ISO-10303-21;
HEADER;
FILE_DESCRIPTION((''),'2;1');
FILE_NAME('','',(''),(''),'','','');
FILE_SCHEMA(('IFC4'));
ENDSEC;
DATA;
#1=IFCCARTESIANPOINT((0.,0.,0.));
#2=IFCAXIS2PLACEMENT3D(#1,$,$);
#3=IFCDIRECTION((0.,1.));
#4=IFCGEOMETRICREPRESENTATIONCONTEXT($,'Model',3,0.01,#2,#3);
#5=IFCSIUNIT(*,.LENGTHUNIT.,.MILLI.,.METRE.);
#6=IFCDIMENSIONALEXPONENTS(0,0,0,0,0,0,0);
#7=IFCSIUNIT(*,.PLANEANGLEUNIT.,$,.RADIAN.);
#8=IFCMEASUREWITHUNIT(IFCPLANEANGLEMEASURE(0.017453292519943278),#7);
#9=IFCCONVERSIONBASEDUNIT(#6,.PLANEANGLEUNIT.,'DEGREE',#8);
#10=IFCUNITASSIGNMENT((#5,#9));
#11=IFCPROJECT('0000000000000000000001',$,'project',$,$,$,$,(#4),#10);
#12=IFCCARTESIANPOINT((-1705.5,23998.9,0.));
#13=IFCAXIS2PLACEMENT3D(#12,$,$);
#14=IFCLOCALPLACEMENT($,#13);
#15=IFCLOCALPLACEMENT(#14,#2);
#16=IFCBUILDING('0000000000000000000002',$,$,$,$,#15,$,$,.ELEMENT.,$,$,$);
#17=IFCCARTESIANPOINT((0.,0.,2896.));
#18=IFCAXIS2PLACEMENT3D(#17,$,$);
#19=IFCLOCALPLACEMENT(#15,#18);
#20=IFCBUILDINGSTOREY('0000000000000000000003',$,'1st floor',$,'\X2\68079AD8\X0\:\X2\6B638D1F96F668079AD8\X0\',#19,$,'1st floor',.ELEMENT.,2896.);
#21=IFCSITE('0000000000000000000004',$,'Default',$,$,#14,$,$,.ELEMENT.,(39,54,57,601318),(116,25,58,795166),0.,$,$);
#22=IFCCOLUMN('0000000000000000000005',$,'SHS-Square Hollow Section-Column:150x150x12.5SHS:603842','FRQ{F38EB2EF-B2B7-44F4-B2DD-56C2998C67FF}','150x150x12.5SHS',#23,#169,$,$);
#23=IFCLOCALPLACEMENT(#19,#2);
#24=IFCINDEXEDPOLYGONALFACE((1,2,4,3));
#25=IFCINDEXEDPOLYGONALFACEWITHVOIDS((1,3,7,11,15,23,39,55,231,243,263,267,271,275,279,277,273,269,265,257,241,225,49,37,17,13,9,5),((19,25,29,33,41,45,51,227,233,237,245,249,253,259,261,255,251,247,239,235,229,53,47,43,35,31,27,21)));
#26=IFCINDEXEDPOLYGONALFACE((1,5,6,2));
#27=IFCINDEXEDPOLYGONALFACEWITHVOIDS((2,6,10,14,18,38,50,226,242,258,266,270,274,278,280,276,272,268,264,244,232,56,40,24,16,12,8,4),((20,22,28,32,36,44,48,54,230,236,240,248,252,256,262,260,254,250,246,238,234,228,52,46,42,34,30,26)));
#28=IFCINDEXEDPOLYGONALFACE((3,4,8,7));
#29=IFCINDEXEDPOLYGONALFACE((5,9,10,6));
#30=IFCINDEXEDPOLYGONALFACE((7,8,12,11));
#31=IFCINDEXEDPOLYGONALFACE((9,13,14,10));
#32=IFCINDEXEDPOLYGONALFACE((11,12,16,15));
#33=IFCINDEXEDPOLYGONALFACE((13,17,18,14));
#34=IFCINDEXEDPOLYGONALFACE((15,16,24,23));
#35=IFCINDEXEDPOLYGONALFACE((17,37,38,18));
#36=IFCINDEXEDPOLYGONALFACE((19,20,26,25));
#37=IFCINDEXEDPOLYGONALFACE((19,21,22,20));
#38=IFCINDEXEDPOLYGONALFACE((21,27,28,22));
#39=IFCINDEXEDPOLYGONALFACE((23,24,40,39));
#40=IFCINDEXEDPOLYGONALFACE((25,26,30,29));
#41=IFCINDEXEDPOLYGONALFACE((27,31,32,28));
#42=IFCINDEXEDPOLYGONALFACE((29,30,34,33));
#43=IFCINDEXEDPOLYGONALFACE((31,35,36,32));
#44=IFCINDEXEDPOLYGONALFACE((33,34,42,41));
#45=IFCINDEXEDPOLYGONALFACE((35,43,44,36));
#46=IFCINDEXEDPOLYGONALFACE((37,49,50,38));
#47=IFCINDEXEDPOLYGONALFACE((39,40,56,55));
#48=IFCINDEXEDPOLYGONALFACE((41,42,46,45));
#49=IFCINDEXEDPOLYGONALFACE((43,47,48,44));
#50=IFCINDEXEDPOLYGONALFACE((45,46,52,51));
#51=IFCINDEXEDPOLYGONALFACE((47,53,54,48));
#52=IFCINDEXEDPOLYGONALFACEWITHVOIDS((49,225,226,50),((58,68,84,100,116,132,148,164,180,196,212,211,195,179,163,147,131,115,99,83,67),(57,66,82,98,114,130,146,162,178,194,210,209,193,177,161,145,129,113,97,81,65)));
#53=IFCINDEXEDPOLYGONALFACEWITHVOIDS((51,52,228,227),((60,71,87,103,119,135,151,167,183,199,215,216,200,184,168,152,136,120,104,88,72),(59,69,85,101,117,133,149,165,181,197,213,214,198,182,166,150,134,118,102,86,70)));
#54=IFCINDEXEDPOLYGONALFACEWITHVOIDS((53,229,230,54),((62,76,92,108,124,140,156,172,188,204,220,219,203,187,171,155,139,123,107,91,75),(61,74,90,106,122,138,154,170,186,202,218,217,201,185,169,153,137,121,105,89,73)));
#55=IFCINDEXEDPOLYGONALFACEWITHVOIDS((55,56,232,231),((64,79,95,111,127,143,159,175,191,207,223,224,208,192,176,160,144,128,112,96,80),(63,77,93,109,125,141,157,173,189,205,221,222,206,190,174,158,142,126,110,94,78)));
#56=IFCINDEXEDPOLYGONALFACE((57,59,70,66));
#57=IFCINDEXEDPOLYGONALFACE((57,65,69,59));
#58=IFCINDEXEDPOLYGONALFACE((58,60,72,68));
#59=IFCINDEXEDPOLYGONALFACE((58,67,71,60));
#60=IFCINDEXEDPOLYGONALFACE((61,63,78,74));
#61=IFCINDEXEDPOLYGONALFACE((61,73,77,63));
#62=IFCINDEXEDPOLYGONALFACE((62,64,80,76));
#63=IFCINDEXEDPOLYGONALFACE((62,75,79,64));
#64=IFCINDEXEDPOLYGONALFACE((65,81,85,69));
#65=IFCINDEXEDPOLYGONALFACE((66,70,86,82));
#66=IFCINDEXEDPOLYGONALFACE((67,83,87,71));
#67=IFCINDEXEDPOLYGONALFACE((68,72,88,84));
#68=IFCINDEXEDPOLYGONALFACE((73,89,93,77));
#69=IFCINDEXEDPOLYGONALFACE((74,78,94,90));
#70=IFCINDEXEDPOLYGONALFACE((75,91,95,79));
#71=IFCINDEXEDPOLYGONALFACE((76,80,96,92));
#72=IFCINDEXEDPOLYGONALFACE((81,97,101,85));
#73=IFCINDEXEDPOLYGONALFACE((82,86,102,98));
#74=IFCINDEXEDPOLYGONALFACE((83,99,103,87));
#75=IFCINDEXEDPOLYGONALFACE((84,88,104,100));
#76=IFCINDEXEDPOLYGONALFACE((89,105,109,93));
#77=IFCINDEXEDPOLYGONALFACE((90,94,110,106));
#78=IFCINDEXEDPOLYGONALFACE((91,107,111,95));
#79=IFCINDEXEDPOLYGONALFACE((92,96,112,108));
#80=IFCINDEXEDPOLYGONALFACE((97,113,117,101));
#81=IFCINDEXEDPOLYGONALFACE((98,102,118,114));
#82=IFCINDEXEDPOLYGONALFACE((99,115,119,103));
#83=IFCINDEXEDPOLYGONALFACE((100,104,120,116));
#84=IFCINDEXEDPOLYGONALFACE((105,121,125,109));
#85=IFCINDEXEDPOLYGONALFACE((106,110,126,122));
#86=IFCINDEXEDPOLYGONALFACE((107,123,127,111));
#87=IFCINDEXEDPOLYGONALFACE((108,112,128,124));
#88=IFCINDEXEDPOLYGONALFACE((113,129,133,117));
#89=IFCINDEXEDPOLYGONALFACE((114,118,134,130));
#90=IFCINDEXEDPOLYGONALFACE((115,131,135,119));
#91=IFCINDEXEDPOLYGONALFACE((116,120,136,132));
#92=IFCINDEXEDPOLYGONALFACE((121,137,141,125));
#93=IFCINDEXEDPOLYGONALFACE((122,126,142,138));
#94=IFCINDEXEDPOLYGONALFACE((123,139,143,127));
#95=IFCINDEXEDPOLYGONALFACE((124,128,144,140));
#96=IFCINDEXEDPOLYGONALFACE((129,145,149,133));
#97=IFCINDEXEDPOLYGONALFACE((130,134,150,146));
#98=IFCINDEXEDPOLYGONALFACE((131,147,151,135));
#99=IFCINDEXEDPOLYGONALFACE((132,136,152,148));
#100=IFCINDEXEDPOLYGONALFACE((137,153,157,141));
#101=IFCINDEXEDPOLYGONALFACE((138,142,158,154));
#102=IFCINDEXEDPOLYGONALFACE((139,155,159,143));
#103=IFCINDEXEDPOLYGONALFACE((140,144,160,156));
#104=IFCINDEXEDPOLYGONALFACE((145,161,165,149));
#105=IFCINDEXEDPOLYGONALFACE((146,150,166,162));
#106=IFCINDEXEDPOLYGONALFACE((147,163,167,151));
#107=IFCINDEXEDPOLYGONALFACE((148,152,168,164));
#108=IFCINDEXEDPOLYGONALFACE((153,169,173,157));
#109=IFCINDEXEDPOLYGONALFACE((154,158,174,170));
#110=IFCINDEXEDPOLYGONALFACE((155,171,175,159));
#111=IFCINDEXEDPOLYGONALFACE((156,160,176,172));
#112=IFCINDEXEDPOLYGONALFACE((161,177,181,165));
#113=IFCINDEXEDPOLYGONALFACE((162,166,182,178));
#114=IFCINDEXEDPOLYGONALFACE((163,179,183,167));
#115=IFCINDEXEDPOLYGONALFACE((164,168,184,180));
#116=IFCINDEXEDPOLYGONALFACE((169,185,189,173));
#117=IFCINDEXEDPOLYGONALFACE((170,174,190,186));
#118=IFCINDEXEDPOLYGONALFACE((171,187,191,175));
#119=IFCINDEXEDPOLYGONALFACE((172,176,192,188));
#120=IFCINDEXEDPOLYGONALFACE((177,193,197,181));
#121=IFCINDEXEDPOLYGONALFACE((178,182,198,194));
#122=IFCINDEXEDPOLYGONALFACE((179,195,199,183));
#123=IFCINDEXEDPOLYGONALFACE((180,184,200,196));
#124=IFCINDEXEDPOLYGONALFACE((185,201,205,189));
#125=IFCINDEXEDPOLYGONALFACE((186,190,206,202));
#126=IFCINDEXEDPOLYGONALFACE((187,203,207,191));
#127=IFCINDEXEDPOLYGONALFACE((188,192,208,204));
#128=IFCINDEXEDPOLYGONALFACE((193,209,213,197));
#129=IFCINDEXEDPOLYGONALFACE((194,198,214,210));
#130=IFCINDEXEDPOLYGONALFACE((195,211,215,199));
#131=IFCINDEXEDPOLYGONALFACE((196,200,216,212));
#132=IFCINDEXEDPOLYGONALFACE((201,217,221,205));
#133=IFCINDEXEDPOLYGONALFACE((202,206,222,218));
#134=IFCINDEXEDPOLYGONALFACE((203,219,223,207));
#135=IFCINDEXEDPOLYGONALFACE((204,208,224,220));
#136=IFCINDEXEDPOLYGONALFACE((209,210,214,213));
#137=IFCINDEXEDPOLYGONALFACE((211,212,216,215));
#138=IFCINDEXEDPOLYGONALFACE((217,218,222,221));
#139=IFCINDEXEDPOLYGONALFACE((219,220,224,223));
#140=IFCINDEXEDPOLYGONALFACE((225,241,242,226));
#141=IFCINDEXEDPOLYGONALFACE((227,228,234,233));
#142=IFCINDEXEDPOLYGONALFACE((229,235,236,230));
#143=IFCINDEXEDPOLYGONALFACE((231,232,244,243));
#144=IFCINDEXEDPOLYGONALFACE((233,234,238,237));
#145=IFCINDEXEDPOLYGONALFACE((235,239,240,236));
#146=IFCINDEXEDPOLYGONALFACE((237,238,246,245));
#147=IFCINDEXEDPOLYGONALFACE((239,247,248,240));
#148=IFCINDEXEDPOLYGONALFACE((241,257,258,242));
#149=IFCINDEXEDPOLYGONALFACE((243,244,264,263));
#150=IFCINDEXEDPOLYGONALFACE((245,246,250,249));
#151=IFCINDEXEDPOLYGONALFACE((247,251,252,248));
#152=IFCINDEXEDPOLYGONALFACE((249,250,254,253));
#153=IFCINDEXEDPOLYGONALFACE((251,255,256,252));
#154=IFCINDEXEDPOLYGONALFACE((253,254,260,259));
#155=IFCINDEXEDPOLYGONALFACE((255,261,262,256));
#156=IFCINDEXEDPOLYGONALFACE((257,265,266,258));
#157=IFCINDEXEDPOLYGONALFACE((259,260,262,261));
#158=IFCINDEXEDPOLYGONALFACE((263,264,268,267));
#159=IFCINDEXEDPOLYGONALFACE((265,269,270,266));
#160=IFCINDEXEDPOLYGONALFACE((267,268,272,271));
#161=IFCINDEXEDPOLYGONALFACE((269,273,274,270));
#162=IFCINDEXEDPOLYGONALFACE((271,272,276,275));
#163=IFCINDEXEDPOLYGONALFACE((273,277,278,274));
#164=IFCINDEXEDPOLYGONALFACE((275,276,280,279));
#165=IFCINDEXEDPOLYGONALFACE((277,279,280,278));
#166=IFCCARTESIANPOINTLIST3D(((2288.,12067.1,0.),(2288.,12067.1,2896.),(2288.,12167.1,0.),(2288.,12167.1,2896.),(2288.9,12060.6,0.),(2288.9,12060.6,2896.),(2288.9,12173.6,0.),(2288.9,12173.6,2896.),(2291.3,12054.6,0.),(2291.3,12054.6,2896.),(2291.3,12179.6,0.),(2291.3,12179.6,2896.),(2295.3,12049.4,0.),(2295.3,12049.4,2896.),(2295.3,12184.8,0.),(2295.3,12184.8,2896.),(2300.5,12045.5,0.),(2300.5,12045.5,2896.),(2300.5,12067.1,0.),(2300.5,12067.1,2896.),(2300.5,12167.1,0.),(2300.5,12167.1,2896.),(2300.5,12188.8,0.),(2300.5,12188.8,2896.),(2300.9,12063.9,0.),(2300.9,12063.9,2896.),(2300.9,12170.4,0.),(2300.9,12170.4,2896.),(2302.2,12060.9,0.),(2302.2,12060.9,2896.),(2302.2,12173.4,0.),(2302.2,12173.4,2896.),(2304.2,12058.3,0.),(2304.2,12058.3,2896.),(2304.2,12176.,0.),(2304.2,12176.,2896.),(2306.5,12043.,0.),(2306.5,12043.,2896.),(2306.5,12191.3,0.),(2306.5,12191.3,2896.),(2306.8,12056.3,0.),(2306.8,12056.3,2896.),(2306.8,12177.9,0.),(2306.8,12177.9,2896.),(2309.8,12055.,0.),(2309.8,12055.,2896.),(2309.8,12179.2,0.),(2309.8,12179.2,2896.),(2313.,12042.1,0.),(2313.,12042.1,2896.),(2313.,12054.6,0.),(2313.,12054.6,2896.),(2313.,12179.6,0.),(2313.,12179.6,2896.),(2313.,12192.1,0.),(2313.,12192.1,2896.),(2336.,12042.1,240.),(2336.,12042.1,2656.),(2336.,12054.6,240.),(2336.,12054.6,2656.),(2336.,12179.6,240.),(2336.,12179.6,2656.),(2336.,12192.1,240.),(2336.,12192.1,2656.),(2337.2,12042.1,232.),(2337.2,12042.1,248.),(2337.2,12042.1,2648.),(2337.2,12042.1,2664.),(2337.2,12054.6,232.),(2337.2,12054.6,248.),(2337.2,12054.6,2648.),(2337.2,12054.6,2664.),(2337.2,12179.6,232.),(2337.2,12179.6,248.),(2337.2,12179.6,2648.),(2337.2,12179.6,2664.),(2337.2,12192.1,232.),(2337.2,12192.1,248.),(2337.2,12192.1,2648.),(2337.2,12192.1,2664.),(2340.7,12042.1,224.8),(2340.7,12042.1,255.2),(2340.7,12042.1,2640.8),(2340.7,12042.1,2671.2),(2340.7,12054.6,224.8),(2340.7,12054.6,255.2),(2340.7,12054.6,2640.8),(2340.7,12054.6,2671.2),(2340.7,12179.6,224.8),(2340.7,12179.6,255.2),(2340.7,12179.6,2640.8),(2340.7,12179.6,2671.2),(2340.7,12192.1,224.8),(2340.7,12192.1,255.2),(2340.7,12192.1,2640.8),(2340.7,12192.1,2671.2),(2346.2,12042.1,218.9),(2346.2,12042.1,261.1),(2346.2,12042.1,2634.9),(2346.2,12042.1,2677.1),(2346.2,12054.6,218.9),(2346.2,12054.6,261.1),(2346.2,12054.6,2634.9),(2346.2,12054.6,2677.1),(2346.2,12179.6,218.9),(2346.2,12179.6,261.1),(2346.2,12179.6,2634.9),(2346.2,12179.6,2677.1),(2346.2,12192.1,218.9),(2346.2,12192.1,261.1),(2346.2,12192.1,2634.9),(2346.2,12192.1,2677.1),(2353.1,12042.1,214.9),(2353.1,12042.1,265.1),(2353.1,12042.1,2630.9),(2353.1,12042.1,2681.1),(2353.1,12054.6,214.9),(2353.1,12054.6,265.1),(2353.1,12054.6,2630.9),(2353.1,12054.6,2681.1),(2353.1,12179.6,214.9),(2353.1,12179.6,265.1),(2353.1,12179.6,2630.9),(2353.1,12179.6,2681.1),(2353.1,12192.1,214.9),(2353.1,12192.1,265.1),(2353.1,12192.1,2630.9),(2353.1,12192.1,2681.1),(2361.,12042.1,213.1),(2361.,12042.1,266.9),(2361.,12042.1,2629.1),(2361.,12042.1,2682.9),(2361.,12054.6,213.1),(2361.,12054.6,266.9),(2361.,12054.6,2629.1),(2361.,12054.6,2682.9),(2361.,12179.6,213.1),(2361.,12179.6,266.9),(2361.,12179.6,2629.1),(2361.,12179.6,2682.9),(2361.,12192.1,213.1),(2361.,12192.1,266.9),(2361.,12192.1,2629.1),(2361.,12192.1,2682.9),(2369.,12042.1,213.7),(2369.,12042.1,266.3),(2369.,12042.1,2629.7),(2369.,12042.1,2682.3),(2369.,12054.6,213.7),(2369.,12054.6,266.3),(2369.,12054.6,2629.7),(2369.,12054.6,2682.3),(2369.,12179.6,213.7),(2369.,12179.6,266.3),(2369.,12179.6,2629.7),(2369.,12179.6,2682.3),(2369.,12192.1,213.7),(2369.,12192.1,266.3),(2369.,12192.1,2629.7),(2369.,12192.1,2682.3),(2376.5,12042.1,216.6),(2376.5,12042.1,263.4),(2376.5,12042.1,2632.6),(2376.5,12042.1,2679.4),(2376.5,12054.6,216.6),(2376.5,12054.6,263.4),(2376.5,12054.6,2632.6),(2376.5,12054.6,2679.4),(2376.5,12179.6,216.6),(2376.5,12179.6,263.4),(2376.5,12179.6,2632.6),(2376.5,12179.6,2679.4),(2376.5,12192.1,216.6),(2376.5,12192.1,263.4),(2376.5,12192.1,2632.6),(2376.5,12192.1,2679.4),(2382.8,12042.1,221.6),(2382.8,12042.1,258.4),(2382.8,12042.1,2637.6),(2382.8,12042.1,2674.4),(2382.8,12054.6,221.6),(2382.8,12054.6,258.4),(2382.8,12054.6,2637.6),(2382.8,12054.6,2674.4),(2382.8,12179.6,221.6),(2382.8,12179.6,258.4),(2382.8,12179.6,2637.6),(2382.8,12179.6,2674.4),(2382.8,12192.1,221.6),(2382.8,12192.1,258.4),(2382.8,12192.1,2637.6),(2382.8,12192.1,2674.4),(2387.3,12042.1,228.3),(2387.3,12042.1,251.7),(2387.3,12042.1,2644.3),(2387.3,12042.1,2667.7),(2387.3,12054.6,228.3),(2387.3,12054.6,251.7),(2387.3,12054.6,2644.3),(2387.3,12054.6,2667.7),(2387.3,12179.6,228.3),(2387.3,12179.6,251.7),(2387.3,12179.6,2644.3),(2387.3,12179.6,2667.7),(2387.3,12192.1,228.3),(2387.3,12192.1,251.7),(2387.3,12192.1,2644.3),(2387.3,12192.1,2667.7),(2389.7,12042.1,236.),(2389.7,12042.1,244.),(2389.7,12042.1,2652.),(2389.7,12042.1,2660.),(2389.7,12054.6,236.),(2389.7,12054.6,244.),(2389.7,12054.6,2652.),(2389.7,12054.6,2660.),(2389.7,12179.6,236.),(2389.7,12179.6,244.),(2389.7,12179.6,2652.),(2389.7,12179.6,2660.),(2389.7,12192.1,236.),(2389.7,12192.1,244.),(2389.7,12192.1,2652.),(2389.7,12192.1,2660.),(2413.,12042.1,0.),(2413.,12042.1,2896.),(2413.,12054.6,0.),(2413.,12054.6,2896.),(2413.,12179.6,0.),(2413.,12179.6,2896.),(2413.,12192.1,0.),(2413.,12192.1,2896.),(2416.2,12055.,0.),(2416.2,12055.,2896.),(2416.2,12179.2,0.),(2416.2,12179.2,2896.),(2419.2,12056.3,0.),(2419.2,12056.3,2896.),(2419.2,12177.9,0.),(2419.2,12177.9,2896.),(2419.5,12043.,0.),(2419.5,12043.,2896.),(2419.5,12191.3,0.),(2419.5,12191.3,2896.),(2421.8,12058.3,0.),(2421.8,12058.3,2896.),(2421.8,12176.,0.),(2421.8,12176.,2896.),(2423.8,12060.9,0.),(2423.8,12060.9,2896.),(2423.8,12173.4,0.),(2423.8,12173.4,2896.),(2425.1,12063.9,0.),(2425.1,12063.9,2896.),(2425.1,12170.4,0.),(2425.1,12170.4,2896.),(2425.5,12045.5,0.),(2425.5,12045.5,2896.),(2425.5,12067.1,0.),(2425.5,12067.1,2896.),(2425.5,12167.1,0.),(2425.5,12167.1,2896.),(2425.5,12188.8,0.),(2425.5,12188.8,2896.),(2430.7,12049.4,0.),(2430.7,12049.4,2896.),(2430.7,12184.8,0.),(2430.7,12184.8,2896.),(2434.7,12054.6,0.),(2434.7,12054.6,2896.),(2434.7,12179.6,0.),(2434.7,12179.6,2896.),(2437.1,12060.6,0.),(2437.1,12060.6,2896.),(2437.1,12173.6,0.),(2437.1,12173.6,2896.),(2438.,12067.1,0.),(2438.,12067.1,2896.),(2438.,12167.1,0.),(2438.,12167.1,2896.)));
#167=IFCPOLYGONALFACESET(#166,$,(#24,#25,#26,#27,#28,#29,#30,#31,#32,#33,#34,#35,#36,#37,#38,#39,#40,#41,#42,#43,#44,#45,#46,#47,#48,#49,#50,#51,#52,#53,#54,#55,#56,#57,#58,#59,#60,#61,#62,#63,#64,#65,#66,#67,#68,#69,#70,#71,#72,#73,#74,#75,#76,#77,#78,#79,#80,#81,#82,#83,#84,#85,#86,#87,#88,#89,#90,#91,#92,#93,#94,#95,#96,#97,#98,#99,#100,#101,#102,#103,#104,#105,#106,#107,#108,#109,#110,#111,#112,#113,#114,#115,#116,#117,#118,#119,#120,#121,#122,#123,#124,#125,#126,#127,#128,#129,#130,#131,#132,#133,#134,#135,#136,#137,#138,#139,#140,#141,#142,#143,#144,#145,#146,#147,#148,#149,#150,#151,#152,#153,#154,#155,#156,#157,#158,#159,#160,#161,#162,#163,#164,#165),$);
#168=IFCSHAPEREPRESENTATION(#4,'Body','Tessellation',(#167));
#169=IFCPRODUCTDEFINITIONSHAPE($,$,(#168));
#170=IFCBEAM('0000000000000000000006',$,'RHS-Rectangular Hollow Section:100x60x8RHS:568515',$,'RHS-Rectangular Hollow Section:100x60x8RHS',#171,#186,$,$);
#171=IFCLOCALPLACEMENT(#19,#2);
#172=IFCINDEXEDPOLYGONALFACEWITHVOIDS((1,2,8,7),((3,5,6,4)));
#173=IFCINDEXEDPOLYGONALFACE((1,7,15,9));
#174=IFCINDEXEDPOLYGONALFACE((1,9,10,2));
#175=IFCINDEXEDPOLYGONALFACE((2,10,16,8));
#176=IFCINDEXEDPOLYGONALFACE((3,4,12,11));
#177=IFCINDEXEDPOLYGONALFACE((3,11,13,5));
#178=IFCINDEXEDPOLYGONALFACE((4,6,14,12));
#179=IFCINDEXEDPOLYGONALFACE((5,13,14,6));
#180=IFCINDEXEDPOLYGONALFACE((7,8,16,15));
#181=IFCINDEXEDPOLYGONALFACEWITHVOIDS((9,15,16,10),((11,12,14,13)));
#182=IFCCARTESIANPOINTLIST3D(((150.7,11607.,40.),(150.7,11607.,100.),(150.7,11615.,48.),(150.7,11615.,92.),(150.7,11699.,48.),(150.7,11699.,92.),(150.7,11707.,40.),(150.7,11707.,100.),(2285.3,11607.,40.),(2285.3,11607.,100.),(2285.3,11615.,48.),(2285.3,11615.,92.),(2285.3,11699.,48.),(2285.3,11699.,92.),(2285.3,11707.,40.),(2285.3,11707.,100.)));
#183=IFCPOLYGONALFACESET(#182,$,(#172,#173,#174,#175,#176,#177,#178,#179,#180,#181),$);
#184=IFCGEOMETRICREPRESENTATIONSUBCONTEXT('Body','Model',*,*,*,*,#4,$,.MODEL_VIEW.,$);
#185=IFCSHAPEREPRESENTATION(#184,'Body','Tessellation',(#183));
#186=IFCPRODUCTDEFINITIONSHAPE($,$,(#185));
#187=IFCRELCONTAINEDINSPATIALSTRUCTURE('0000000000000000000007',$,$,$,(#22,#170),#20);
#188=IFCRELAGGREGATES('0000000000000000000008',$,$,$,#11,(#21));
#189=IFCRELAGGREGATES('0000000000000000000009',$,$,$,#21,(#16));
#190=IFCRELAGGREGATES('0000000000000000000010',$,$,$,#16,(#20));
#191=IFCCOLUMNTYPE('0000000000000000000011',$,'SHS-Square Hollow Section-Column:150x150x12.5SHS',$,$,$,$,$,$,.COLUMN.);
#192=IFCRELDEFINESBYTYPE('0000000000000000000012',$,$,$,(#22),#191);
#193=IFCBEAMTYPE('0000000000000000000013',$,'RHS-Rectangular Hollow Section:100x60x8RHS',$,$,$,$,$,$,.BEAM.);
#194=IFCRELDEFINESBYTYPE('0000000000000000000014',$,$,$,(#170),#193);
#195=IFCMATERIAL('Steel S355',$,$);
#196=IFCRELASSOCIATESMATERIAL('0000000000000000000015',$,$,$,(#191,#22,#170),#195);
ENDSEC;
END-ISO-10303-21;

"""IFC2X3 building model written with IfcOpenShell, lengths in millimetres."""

from ifc_helpers import new_model, entity, si_unit, converted_unit, direction, frame, frame_2d, origin, origin_2d, place, context, subcontext, project, spatial, circle_curve, rectangle, hollow_rectangle, outline, extrude, boolean, material, type_object, element, save


model = new_model("IFC2X3")

# Units and contexts
model_context = context("Model", 3, precision=0.01, world=origin(), true_north=direction((0.0, 1.0)))
body_context = subcontext(model_context, "Body", "Model", "MODEL_VIEW")
ifc_project = project(units=[si_unit("LENGTHUNIT", "METRE", prefix="MILLI"), converted_unit("PLANEANGLEUNIT", "DEGREE", entity("IfcPlaneAngleMeasure", 0.017453292519943278), si_unit("PLANEANGLEUNIT", "RADIAN"), dimensions=[0, 0, 0, 0, 0, 0, 0])], contexts=[model_context])

# Site, building, storey
site_placement = place(None, frame((-1705.5, 23998.9, 0.0)))
site = spatial("IfcSite", under=ifc_project, at=site_placement, Name="Default", CompositionType="ELEMENT", RefLatitude=(39, 54, 57, 601318), RefLongitude=(116, 25, 58, 795166), RefElevation=0.0)
building_placement = place(site_placement, origin())
building = spatial("IfcBuilding", under=site, at=building_placement, CompositionType="ELEMENT")
storey_placement = place(building_placement, frame((0.0, 0.0, 2896.0)))
storey = spatial("IfcBuildingStorey", under=building, at=storey_placement, Name="1st floor", ObjectType="标高:正负零标高", LongName="1st floor", CompositionType="ELEMENT", Elevation=2896.0)

# Shared definitions
ifc_material_1 = material(Name="Steel S355")

# Column, openings
column_type_1 = type_object("IfcColumnType", Name="SHS-Square Hollow Section-Column:150x150x12.5SHS", PredefinedType="COLUMN", material=ifc_material_1)
column_1_placement = place(storey_placement, frame((2363.0, 12117.1, 2896.0), z_axis=(0.0, 0.0, 1.0), x_axis=(0.0, 1.0, 0.0)))
column_1 = element("IfcColumn", 1, at=column_1_placement, inside=storey, type_object=column_type_1, material=ifc_material_1, Name="SHS-Square Hollow Section-Column:150x150x12.5SHS:603842", Description="FRQ{F38EB2EF-B2B7-44F4-B2DD-56C2998C67FF}", ObjectType="150x150x12.5SHS", context=model_context, shape_type="SweptSolid", body=[
    extrude(hollow_rectangle(XDim=150.0, YDim=150.0, WallThickness=12.5, InnerFilletRadius=12.5, OuterFilletRadius=25.0, at=origin_2d()), origin(), (0.0, 0.0, -1.0), 2896.0),
])
opening_1_placement = place(column_1_placement, frame((-175.1, 0.0, 0.0), z_axis=(1.0, 0.0, 0.0), x_axis=(0.0, 1.0, 0.0)))
element("IfcOpeningElement", 2, at=opening_1_placement, cuts=column_1, ObjectType="Opening", context=model_context, shape_type="SweptSolid", body=[
    extrude(outline(circle_curve(frame_2d((0.0, -240.0), x_axis=(1.0, 0.0)), 27.0)), origin(), (0.0, 0.0, 1.0), 350.2),
])
opening_2_placement = place(column_1_placement, frame((-175.1, 0.0, -2896.0), z_axis=(1.0, 0.0, 0.0), x_axis=(0.0, 1.0, 0.0)))
element("IfcOpeningElement", 3, at=opening_2_placement, cuts=column_1, ObjectType="Opening", context=model_context, shape_type="SweptSolid", body=[
    extrude(outline(circle_curve(frame_2d((0.0, 240.0), x_axis=(1.0, 0.0)), 27.0)), origin(), (0.0, 0.0, 1.0), 350.2),
])

# Beam
beam_type_1 = type_object("IfcBeamType", Name="RHS-Rectangular Hollow Section:100x60x8RHS", PredefinedType="BEAM")
beam_1_placement = place(storey_placement, frame((150.7, 11707.0, 70.0)))
element("IfcBeam", 4, at=beam_1_placement, inside=storey, type_object=beam_type_1, material=ifc_material_1, Name="RHS-Rectangular Hollow Section:100x60x8RHS:568515", ObjectType="RHS-Rectangular Hollow Section:100x60x8RHS", context=body_context, shape_type="SweptSolid", body=[
    boolean("DIFFERENCE", extrude(rectangle(XDim=60.0, YDim=100.0, at=frame_2d((0.0, 0.0), x_axis=(1.0, 0.0))), frame((0.0, -50.0, 0.0), z_axis=(1.0, 0.0, 0.0), x_axis=(0.0, 0.0, -1.0)), (0.0, 0.0, 1.0), 2134.6), extrude(rectangle(XDim=44.0, YDim=84.0, at=frame_2d((0.0, 0.0), x_axis=(0.0, 1.0))), frame((2134.6, -50.0, 0.0), z_axis=(-1.0, 0.0, 0.0), x_axis=(0.0, 1.0, 0.0)), (0.0, 0.0, 1.0), 2134.6)),
])

save(model, "model.ifc")
